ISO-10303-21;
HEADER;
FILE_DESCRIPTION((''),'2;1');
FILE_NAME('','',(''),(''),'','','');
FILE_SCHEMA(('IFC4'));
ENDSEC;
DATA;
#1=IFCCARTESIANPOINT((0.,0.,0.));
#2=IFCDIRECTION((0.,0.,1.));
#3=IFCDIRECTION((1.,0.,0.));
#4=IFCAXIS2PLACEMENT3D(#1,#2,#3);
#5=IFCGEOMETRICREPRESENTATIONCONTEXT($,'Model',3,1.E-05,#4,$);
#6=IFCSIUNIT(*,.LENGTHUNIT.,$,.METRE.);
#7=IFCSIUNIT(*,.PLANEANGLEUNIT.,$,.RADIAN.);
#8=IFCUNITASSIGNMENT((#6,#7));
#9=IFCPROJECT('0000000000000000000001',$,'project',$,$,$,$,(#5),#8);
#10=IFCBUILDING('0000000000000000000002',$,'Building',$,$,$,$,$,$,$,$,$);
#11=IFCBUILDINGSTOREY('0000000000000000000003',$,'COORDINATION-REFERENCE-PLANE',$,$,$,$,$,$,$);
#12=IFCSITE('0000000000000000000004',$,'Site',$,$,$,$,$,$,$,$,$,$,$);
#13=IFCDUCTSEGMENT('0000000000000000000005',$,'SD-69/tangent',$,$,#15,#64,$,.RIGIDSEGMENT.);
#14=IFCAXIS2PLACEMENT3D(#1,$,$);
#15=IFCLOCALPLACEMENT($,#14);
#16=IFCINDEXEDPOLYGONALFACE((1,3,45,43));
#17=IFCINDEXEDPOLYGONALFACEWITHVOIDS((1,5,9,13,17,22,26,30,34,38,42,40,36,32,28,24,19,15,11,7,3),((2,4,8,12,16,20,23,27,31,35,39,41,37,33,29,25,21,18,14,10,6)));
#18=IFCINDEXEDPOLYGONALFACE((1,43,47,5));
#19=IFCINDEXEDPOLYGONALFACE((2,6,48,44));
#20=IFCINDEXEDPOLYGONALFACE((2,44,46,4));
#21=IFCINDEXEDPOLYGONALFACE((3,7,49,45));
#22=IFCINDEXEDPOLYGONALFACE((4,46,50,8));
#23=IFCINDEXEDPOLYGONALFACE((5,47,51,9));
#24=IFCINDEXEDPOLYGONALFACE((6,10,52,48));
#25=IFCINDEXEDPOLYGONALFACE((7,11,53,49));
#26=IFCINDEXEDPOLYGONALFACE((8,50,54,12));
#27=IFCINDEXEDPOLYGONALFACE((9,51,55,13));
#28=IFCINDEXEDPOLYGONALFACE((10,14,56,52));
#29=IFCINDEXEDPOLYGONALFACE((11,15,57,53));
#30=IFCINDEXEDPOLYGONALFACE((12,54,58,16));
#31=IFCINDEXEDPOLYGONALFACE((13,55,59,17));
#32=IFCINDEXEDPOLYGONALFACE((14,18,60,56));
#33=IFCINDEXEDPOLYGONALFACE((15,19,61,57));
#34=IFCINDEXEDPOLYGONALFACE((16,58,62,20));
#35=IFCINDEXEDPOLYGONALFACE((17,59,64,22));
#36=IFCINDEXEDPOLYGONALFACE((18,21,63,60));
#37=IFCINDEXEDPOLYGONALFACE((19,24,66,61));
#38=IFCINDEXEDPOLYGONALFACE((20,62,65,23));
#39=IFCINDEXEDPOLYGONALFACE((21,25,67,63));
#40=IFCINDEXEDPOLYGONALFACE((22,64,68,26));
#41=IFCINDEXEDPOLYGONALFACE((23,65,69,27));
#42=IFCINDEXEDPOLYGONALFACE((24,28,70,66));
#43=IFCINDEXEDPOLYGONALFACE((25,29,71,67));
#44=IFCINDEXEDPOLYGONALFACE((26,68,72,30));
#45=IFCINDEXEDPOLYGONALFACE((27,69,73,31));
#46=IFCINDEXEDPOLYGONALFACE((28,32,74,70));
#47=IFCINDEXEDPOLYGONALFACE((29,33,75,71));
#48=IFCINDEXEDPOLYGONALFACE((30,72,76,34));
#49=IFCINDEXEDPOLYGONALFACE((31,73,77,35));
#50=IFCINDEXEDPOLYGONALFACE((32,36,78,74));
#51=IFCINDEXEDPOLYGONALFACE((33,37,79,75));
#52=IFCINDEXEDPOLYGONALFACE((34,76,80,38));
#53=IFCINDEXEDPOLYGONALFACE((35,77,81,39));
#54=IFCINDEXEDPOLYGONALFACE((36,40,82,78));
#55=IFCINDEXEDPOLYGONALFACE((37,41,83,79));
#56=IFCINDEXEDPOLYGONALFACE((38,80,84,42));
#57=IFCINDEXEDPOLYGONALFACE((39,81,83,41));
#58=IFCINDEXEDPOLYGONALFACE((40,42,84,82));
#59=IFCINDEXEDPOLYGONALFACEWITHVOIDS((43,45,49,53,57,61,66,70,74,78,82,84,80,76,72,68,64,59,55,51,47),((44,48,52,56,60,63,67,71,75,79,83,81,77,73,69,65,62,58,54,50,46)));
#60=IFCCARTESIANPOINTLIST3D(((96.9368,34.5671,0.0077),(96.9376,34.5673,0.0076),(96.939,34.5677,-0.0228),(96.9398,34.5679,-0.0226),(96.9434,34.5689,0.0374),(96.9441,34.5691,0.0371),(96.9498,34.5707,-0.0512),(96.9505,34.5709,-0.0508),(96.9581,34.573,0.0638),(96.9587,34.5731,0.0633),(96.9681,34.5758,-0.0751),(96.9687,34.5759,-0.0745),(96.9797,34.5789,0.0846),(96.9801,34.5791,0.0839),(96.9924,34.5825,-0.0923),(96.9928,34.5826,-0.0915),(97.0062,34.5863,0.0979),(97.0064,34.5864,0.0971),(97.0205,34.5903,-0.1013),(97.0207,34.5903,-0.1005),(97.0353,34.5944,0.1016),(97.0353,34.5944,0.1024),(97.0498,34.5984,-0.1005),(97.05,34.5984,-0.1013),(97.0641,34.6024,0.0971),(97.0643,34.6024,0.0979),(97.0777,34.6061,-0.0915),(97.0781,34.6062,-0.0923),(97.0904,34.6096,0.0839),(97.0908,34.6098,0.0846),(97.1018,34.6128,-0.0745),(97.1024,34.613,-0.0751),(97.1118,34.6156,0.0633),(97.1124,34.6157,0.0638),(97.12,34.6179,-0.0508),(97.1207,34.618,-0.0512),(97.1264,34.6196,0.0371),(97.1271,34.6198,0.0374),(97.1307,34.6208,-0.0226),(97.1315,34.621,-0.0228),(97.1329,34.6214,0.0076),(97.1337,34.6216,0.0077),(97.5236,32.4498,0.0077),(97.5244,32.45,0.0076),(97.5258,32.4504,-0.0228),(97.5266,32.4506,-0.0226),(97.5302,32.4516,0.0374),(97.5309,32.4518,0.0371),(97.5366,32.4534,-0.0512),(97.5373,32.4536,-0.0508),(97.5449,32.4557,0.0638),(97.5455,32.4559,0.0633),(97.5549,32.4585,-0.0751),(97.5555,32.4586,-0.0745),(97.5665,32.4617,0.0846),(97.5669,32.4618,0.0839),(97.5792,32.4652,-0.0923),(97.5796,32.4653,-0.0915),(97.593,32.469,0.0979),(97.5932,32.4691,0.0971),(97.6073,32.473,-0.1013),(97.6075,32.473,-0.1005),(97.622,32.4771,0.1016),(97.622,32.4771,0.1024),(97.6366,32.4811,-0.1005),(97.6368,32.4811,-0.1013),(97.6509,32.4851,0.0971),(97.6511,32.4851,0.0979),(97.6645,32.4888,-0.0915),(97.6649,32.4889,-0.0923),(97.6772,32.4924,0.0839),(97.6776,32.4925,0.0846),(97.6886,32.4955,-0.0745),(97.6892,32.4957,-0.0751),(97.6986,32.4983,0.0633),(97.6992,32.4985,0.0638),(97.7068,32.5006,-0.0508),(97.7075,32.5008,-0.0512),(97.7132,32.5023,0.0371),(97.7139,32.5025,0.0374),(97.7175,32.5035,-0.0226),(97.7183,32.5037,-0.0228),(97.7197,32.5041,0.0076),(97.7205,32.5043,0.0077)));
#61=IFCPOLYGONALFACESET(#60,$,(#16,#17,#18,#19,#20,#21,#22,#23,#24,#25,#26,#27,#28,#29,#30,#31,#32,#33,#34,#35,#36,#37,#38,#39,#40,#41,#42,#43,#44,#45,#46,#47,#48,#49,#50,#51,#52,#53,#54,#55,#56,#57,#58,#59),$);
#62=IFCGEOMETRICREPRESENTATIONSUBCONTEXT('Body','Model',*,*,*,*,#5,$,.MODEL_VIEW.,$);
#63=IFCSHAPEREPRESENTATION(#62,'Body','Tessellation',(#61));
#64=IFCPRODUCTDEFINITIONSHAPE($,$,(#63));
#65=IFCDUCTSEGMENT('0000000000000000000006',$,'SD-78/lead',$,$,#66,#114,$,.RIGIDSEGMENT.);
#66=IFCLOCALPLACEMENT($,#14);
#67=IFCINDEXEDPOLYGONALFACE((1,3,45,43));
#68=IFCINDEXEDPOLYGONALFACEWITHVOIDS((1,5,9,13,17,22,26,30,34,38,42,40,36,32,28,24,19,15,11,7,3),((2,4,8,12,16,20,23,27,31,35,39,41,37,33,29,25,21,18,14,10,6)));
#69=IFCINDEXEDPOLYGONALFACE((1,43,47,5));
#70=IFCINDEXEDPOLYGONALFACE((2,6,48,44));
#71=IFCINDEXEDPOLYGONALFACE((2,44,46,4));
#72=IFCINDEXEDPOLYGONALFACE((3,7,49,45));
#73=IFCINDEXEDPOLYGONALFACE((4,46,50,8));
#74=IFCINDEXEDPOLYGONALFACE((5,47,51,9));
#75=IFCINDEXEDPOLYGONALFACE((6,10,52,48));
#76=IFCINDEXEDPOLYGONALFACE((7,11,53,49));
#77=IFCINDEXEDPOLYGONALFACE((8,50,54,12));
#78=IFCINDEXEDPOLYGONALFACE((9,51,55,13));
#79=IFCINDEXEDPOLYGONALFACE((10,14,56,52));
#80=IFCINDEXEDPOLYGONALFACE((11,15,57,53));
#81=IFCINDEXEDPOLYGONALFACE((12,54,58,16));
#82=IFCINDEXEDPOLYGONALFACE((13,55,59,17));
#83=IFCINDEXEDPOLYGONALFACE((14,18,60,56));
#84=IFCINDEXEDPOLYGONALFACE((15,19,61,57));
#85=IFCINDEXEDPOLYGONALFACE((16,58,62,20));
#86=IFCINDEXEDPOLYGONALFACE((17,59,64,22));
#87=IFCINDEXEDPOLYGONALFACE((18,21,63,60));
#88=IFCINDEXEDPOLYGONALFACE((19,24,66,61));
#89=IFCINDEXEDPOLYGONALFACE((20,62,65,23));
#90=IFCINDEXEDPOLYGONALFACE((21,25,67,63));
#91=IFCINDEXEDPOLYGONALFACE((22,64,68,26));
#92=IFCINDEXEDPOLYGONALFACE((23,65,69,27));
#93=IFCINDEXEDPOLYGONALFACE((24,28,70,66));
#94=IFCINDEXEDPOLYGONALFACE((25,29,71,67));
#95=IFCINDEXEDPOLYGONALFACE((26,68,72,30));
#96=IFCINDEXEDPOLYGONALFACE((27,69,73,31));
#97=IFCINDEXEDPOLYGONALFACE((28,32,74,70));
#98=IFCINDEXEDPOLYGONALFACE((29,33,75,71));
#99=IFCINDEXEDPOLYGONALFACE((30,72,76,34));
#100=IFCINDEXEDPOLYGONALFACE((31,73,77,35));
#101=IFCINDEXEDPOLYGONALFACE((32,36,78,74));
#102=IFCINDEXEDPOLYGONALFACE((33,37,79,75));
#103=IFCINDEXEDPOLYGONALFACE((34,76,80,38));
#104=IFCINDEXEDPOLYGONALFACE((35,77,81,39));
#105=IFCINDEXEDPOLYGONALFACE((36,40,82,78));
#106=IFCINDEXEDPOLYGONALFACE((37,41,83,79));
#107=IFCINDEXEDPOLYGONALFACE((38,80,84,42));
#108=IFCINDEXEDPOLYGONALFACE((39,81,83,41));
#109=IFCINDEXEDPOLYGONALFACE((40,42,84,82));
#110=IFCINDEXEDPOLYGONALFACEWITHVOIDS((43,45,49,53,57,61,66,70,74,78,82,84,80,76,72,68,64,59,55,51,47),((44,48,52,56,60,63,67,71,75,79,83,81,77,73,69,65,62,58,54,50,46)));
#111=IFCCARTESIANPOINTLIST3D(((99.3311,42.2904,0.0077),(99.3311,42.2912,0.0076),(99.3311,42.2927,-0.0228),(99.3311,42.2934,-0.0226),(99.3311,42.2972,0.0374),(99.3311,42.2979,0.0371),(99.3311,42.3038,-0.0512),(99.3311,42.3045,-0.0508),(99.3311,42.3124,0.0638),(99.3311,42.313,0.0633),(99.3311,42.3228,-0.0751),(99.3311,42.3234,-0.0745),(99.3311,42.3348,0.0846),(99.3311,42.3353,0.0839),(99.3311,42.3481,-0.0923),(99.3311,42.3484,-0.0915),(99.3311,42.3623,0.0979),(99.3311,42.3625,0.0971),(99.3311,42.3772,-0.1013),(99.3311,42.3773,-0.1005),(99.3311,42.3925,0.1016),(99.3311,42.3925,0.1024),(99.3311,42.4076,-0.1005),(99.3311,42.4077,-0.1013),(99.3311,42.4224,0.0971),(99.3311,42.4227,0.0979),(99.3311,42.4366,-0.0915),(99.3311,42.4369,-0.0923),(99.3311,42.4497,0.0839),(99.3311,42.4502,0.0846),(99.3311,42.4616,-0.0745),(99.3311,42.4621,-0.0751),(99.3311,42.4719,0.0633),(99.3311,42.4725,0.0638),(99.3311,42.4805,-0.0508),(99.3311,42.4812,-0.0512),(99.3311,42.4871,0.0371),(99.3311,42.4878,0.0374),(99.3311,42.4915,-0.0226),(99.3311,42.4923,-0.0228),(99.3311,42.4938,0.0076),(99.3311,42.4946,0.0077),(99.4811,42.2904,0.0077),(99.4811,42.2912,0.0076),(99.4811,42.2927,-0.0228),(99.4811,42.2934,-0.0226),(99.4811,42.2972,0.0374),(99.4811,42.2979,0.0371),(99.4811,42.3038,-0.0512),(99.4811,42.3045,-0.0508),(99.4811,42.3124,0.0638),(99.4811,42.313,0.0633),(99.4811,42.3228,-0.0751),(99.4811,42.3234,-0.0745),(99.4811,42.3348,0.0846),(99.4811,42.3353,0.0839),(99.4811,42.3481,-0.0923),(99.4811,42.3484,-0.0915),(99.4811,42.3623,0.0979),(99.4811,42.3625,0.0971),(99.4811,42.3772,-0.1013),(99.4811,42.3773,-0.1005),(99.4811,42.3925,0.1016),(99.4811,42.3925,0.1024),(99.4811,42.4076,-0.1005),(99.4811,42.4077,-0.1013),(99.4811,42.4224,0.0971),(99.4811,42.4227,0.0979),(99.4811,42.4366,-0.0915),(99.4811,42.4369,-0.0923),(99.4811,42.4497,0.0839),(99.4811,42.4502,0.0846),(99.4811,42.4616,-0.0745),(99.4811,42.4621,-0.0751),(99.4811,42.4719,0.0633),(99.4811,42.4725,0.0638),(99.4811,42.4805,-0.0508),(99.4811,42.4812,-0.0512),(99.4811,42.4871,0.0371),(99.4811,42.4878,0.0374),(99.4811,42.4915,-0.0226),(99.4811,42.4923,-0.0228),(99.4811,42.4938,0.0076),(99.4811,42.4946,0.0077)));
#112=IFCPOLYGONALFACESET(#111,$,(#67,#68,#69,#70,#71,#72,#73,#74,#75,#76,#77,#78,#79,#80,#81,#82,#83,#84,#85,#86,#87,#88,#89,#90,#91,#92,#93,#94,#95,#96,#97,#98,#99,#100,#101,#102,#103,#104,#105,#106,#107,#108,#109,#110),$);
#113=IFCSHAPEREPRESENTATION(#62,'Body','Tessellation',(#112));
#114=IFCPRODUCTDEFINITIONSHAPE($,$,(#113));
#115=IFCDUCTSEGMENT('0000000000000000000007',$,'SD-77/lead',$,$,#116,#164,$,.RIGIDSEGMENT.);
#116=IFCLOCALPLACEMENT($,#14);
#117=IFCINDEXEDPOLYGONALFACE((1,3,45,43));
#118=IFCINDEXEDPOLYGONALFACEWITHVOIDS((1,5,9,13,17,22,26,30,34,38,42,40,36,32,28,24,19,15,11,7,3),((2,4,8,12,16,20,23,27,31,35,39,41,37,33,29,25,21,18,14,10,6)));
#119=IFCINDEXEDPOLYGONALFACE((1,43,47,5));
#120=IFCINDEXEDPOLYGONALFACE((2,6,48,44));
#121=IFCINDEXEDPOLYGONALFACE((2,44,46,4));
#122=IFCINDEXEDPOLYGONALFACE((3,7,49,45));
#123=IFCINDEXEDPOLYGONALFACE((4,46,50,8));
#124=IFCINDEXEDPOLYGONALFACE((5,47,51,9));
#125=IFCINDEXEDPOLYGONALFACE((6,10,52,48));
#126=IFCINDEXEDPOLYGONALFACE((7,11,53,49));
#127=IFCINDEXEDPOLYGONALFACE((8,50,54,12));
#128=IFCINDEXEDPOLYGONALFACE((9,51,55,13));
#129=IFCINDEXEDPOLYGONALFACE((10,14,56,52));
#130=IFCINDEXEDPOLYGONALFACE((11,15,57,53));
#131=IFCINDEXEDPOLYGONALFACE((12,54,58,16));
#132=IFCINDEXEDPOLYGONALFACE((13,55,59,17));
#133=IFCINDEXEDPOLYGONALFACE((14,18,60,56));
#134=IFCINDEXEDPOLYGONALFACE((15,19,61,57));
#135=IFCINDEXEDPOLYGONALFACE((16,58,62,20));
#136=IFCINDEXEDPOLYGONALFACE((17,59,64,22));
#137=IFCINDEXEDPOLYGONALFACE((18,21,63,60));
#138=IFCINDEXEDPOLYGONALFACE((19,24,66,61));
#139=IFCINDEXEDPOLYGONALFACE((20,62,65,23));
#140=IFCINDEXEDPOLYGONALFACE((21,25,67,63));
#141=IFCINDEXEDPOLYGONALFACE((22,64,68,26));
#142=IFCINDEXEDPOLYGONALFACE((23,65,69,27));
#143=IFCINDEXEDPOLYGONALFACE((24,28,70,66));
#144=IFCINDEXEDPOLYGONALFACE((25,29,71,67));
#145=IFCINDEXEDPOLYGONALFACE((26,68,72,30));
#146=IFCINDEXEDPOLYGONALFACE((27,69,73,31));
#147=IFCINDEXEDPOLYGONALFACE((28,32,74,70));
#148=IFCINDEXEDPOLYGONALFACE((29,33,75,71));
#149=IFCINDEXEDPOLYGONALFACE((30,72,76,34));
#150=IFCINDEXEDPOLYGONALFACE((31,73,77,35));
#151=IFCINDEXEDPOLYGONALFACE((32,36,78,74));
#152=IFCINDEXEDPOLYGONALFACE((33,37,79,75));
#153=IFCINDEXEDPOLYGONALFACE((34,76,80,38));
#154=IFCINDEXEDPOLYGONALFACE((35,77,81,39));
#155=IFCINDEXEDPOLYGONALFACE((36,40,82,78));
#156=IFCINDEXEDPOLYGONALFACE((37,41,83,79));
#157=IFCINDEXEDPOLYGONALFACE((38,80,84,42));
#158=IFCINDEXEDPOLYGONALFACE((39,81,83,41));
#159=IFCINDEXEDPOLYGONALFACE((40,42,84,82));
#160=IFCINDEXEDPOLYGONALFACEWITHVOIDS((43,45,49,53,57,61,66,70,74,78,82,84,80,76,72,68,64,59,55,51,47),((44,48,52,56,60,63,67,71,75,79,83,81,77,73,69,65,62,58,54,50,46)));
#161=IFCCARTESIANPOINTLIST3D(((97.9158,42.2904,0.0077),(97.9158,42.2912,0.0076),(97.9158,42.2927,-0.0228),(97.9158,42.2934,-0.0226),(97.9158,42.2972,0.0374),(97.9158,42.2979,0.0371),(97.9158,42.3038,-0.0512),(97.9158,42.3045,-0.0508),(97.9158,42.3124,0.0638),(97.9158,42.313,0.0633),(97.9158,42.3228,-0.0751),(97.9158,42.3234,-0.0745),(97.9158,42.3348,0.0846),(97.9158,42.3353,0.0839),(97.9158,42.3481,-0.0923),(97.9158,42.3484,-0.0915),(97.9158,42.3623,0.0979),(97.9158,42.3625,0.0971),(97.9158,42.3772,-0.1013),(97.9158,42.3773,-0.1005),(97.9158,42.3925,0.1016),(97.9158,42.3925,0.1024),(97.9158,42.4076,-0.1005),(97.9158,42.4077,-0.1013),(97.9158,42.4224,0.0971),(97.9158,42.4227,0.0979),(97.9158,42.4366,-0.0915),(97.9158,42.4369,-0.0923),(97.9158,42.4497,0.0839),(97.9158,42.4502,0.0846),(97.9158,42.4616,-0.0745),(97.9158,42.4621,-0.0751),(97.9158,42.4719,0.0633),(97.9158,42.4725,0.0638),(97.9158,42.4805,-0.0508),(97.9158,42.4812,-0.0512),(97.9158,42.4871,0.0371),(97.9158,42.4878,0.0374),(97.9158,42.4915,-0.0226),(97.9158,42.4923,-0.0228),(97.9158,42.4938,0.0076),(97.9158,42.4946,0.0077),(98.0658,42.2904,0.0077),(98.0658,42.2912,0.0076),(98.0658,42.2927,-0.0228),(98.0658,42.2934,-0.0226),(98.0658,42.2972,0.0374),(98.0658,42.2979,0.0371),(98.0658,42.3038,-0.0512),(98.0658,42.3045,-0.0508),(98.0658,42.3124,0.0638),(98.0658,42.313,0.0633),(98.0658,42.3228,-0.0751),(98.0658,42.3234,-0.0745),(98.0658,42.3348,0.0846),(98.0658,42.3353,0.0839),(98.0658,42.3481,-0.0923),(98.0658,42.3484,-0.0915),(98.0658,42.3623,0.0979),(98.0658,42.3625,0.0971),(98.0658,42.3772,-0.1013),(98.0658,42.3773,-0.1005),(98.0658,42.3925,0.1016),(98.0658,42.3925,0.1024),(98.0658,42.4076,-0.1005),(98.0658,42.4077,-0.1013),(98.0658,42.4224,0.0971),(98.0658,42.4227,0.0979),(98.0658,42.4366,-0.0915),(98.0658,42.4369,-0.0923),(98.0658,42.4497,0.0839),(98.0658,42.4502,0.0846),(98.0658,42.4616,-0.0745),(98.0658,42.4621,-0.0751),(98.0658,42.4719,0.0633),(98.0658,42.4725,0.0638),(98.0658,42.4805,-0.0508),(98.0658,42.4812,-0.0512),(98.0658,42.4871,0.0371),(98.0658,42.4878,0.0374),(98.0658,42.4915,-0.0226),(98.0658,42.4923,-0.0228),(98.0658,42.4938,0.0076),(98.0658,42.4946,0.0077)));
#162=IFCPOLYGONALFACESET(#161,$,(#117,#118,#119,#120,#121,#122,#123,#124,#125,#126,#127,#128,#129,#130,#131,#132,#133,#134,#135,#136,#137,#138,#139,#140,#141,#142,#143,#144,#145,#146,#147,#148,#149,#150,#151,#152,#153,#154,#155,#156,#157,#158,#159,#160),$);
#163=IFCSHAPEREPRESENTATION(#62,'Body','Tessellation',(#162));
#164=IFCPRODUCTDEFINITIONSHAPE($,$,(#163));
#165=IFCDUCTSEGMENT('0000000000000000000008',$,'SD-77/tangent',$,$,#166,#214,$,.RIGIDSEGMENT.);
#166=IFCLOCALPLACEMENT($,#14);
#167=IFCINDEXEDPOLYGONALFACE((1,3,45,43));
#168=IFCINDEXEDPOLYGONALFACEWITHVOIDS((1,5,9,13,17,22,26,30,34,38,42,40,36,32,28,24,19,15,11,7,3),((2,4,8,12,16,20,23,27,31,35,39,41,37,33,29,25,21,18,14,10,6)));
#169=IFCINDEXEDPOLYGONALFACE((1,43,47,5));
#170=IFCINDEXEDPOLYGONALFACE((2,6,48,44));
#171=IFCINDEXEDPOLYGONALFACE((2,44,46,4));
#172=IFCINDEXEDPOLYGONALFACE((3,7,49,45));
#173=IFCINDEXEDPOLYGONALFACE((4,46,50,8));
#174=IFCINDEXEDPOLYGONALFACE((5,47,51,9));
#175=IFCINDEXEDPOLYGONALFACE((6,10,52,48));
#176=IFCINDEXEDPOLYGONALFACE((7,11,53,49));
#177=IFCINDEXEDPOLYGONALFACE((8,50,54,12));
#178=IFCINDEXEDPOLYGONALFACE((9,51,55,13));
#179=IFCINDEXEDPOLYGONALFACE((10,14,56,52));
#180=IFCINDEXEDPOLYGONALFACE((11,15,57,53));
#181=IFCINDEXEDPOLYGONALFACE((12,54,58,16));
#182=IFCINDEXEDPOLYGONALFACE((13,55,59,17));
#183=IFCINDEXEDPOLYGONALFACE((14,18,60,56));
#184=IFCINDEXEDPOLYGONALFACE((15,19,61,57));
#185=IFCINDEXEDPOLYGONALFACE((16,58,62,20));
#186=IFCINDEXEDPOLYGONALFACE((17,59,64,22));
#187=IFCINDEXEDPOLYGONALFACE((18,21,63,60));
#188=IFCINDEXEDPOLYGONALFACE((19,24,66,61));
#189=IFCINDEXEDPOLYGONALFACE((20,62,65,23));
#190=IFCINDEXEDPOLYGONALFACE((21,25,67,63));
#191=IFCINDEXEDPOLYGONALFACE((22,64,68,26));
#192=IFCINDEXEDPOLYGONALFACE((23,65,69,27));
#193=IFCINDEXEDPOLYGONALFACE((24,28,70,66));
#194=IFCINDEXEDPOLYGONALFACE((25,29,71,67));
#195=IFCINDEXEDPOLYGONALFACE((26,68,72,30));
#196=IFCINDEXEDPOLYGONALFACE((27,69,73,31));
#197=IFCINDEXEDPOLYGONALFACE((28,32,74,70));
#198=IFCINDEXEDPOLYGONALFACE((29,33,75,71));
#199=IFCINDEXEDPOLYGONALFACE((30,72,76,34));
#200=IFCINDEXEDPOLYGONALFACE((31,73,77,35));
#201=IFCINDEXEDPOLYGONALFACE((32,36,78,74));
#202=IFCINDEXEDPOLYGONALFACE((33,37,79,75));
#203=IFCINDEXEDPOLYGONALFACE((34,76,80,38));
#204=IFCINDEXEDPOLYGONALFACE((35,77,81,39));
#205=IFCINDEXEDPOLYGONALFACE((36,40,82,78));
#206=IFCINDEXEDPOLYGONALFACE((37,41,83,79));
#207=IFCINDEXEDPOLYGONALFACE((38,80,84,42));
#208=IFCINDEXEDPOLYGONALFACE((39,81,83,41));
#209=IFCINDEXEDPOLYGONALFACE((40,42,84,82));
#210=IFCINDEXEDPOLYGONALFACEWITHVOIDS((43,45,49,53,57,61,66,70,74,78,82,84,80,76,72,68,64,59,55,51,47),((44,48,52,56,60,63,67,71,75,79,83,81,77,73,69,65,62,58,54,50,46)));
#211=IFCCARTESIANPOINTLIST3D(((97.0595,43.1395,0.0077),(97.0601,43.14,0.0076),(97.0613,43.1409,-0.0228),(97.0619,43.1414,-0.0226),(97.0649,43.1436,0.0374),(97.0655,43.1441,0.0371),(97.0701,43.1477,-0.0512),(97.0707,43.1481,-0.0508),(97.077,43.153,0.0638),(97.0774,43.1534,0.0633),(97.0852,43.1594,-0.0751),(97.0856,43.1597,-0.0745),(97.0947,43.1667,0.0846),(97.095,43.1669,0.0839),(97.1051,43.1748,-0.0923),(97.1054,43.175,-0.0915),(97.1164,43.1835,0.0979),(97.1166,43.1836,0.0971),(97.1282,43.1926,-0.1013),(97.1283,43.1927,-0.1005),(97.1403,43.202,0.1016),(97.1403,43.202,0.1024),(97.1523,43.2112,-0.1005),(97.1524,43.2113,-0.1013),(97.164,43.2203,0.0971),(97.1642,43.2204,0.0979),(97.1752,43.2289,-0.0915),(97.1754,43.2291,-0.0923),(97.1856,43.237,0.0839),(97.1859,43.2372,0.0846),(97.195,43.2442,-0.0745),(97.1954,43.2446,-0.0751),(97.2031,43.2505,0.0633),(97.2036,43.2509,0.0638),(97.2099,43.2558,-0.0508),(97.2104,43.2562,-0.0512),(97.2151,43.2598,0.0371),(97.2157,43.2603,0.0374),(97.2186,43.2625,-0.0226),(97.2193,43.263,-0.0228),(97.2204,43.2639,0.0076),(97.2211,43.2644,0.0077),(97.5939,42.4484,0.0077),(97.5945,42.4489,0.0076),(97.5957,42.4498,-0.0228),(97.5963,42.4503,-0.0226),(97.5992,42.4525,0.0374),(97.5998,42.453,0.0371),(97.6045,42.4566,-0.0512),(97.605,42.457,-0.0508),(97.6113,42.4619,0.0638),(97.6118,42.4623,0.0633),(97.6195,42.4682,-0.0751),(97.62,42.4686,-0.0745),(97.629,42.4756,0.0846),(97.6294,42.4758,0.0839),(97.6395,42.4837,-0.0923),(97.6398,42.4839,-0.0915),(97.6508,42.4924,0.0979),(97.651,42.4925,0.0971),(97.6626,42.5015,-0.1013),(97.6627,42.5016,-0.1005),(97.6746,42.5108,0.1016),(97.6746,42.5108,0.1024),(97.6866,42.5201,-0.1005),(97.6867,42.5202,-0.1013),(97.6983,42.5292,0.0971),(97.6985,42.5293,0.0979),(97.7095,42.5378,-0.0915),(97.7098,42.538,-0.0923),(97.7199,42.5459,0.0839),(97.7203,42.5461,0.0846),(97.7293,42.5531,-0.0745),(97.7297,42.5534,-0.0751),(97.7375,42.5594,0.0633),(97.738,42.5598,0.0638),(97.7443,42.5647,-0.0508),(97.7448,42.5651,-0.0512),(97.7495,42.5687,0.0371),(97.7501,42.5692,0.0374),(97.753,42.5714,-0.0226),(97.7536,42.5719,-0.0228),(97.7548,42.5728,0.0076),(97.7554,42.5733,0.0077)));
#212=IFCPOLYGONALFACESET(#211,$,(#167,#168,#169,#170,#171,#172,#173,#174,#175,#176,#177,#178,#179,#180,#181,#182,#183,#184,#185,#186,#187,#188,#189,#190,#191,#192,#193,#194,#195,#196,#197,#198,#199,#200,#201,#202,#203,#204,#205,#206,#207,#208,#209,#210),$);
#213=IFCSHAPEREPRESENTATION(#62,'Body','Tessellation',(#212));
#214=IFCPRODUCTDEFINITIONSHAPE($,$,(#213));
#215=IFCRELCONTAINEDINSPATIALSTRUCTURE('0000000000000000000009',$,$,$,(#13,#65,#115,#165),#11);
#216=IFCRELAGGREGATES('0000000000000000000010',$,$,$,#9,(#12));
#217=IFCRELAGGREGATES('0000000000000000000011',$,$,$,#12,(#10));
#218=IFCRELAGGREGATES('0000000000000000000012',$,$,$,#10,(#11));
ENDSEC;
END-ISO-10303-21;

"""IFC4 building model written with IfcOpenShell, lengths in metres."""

from ifc_helpers import new_model, si_unit, frame, origin_with_axes, place, context, subcontext, project, spatial, hollow_circle, extrude, element, save


model = new_model("IFC4")

# Units and contexts
model_context = context("Model", 3, precision=1e-05, world=origin_with_axes())
body_context_1 = subcontext(model_context, "Body", "Model", "MODEL_VIEW")
ifc_project = project(units=[si_unit("LENGTHUNIT", "METRE"), si_unit("PLANEANGLEUNIT", "RADIAN")], contexts=[model_context])

# Site, building, storey
site = spatial("IfcSite", under=ifc_project, Name="Site")
building = spatial("IfcBuilding", under=site, Name="Building")
storey = spatial("IfcBuildingStorey", under=building, Name="COORDINATION-REFERENCE-PLANE")

# Duct segment
duct_segment_1_placement = place(None, frame((97.622, 32.4771, 0.0), z_axis=(-0.267077, 0.963675, 0.0), x_axis=(0.0, 0.0, 1.0)))
element("IfcDuctSegment", 1, at=duct_segment_1_placement, inside=storey, Name="SD-69/tangent", PredefinedType="RIGIDSEGMENT", context=body_context_1, shape_type="SweptSolid", body=[
    extrude(hollow_circle(Radius=0.1024, WallThickness=0.0008), origin_with_axes(), (0.0, 0.0, 1.0), 2.1971),
])

# Duct segments
for number, where, z_axis, x_axis, name in (
    (2, (99.3311, 42.3925, 0.0), (1.0, 0.0, 0.0), (0.0, 0.0, 1.0), "SD-78/lead"),
    (3, (98.0658, 42.3925, 0.0), (-1.0, 0.0, 0.0), (0.0, 0.0, 1.0), "SD-77/lead"),
):
    element("IfcDuctSegment", number, at=place(None, frame(where, z_axis=z_axis, x_axis=x_axis)), inside=storey, Name=name, PredefinedType="RIGIDSEGMENT", context=body_context_1, shape_type="SweptSolid", body=[
        extrude(hollow_circle(Radius=0.1024, WallThickness=0.0008), origin_with_axes(), (0.0, 0.0, 1.0), 0.15),
    ])

# Duct segment
duct_segment_2_placement = place(None, frame((97.6746, 42.5108, 0.0), z_axis=(-0.611676, 0.791108, 0.0), x_axis=(0.0, 0.0, 1.0)))
element("IfcDuctSegment", 4, at=duct_segment_2_placement, inside=storey, Name="SD-77/tangent", PredefinedType="RIGIDSEGMENT", context=body_context_1, shape_type="SweptSolid", body=[
    extrude(hollow_circle(Radius=0.1024, WallThickness=0.0008), origin_with_axes(), (0.0, 0.0, 1.0), 0.8736),
])

save(model, "model.ifc")
